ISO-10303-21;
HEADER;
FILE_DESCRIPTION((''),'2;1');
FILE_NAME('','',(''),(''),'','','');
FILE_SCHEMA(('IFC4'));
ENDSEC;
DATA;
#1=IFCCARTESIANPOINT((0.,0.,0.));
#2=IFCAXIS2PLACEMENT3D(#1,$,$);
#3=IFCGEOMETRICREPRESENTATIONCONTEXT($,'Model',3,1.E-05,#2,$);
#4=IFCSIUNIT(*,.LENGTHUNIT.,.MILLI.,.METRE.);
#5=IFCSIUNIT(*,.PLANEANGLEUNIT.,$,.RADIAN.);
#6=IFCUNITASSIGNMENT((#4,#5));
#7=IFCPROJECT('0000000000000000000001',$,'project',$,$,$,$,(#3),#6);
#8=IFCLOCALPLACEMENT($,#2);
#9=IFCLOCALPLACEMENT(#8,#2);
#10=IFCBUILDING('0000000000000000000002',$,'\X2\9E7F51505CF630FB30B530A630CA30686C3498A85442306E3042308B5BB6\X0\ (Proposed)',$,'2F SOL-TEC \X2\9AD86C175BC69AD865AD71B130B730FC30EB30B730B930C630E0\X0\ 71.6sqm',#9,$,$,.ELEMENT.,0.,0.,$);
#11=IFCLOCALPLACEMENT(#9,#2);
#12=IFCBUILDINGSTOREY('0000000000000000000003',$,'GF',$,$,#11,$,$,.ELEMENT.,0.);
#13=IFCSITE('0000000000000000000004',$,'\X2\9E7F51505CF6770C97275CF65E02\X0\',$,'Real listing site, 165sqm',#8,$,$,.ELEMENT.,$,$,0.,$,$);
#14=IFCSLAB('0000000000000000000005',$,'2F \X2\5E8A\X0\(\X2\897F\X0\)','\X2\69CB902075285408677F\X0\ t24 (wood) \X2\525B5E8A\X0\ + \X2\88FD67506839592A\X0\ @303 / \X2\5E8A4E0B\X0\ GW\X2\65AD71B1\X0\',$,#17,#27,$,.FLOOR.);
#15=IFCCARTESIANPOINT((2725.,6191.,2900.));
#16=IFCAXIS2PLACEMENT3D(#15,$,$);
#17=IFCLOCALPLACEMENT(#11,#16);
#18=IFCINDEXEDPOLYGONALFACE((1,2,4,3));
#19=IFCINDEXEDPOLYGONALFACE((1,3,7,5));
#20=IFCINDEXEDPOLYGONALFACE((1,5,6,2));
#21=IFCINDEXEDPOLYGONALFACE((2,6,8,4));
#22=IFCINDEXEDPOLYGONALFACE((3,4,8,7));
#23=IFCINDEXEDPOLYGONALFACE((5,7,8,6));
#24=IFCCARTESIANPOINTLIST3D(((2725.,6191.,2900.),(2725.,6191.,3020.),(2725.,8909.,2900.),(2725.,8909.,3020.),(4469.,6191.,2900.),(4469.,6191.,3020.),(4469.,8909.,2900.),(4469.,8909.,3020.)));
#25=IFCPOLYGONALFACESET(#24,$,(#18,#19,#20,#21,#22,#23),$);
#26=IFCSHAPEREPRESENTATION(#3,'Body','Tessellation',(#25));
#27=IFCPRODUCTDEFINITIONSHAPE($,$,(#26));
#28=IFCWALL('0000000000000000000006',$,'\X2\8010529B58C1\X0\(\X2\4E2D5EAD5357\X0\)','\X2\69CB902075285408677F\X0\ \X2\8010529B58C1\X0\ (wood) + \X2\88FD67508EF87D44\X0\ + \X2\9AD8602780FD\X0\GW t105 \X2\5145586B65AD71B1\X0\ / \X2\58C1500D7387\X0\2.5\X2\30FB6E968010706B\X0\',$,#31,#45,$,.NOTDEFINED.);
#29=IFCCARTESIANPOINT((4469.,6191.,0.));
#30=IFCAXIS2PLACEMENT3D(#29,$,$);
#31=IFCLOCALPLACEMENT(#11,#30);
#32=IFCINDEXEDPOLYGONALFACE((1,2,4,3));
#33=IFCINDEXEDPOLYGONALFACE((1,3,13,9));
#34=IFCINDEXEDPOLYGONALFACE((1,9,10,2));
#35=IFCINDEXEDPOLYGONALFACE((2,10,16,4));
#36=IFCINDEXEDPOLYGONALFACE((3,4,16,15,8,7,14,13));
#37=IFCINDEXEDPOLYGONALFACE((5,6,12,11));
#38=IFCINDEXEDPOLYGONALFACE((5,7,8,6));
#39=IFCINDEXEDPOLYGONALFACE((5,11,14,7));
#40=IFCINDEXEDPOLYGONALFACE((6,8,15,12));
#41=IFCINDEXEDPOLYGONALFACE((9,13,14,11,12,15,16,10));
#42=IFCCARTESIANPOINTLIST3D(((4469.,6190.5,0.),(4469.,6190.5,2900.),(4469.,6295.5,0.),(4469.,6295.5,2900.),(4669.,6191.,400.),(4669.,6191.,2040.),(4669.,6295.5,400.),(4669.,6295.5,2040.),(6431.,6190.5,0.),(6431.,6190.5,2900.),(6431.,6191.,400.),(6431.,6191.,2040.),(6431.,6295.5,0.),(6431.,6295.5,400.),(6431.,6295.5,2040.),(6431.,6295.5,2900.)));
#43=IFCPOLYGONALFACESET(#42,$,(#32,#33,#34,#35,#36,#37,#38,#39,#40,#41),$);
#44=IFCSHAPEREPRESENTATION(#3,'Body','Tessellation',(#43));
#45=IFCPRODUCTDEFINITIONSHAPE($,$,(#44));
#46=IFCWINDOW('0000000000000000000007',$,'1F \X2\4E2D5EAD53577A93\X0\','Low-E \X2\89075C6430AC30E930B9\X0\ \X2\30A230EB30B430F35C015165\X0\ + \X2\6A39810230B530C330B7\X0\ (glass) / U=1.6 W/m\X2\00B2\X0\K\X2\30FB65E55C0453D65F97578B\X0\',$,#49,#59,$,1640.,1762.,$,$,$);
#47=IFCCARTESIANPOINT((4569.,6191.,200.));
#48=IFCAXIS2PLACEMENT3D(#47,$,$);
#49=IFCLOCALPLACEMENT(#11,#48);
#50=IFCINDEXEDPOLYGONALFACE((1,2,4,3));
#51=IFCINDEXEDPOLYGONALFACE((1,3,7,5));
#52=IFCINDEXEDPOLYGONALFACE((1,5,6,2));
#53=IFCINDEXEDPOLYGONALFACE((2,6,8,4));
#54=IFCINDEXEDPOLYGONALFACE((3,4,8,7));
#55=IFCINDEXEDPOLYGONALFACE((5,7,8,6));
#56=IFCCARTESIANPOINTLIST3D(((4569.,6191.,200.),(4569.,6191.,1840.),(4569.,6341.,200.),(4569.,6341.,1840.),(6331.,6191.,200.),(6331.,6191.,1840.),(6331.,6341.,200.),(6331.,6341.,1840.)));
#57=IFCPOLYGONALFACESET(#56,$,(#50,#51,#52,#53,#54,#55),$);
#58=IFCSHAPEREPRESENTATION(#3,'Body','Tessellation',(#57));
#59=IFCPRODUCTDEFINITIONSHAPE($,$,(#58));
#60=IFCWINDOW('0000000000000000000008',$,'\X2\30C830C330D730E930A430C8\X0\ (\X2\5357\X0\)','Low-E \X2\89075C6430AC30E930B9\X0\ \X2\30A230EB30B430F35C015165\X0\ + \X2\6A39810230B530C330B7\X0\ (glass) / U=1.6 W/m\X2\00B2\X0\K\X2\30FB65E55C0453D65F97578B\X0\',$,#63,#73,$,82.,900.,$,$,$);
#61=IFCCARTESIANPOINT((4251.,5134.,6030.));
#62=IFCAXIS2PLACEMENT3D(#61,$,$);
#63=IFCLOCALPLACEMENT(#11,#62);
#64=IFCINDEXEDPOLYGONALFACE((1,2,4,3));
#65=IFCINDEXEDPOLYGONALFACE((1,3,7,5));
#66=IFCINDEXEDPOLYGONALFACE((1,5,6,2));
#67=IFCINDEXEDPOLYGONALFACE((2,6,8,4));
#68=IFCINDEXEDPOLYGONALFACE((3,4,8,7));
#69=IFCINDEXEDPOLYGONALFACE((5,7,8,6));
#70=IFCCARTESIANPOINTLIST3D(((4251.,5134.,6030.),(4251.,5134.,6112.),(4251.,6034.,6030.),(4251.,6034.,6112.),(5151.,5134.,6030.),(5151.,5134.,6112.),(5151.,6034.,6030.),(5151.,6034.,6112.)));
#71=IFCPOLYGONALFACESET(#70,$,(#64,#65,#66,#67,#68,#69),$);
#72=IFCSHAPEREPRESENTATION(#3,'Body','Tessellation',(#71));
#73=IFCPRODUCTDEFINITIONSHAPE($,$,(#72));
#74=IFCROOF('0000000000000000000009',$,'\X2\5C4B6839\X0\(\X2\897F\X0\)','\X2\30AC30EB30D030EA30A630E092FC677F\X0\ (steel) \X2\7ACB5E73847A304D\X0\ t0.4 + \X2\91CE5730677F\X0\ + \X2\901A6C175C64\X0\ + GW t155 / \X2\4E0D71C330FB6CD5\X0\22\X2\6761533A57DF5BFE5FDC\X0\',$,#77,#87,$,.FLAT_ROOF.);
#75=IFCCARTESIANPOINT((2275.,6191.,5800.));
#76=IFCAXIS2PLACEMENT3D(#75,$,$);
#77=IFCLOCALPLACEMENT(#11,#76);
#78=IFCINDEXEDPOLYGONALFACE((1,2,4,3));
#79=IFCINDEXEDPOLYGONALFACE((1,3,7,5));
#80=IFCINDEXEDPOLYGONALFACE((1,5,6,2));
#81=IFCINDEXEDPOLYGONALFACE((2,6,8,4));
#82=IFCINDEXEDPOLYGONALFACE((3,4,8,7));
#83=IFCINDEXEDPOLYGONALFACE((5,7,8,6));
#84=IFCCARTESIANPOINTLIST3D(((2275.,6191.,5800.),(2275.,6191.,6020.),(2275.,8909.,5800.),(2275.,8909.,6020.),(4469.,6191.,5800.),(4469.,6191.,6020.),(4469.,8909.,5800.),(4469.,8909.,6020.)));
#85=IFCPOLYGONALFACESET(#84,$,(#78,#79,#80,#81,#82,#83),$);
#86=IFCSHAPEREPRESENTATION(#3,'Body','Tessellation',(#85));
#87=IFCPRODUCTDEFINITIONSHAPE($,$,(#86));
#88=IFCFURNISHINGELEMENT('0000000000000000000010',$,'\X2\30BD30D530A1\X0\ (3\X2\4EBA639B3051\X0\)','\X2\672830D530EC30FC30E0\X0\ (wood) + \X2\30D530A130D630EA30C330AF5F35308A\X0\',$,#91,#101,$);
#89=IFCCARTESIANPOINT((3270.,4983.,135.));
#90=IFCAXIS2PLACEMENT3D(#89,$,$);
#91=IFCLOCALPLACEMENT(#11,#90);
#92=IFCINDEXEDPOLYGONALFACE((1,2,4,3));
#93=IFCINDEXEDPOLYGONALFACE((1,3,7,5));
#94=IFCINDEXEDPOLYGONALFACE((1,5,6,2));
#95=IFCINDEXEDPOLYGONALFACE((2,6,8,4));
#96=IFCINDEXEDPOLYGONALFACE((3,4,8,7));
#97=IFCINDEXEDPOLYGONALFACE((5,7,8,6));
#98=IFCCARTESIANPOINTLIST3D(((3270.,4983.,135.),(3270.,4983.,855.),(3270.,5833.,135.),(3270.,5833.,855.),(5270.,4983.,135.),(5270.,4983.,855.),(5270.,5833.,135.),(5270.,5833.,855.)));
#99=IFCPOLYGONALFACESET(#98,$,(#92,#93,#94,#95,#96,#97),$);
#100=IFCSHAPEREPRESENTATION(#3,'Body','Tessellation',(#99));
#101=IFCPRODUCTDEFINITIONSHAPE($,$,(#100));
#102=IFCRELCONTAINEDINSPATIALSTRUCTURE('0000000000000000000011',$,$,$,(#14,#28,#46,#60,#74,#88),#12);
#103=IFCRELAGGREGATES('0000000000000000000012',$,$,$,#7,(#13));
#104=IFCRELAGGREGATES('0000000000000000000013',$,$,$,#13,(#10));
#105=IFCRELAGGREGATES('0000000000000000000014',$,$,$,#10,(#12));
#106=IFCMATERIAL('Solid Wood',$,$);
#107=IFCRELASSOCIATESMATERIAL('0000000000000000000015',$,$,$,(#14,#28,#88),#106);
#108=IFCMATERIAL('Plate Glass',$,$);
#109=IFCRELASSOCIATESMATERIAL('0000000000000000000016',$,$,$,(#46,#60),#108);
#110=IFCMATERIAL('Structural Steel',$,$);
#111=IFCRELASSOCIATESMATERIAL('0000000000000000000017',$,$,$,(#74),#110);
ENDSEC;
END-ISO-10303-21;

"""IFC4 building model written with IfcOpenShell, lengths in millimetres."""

from ifc_helpers import new_model, si_unit, frame, frame_2d, origin, place, context, project, spatial, rectangle, extrude, material, element, fill, save


model = new_model("IFC4")

# Units and contexts
model_context = context("Model", 3, precision=1e-05, world=origin())
ifc_project = project(units=[si_unit("LENGTHUNIT", "METRE", prefix="MILLI"), si_unit("PLANEANGLEUNIT", "RADIAN")], contexts=[model_context])

# Site, building, storey
site_placement = place(None, origin())
site = spatial("IfcSite", under=ifc_project, at=site_placement, Name="鹿児島県霧島市", ObjectType="Real listing site, 165sqm", CompositionType="ELEMENT", RefElevation=0.0)
building_placement = place(site_placement, origin())
building = spatial("IfcBuilding", under=site, at=building_placement, Name="鹿児島・サウナと水風呂のある家 (Proposed)", ObjectType="2F SOL-TEC 高気密高断熱シールシステム 71.6sqm", CompositionType="ELEMENT", ElevationOfRefHeight=0.0, ElevationOfTerrain=0.0)
storey_placement = place(building_placement, origin())
storey = spatial("IfcBuildingStorey", under=building, at=storey_placement, Name="GF", CompositionType="ELEMENT", Elevation=0.0)

# Shared definitions
ifc_material_1 = material(Name="Solid Wood")

# Slab
slab_1_placement = place(storey_placement, frame((2725.0, 6191.0, 2900.0)))
element("IfcSlab", 1, at=slab_1_placement, inside=storey, material=ifc_material_1, Name="2F 床(西)", Description="構造用合板 t24 (wood) 剛床 + 製材根太 @303 / 床下 GW断熱", PredefinedType="FLOOR", context=model_context, shape_type="SweptSolid", body=[
    extrude(rectangle(XDim=1744.0, YDim=2718.0, at=frame_2d((872.0, 1359.0))), frame((2725.0, 6191.0, 2900.0)), (0.0, 0.0, 1.0), 120.0),
])

# Wall, opening, window
wall_placement = place(storey_placement, frame((4469.0, 6191.0, 0.0)))
wall = element("IfcWall", 2, at=wall_placement, inside=storey, material=ifc_material_1, Name="耐力壁(中庭南)", Description="構造用合板 耐力壁 (wood) + 製材軸組 + 高性能GW t105 充填断熱 / 壁倍率2.5・準耐火", PredefinedType="NOTDEFINED", context=model_context, shape_type="SweptSolid", body=[
    extrude(rectangle(XDim=1962.0, YDim=105.0, at=frame_2d((981.0, 52.0))), frame((4469.0, 6191.0, 0.0)), (0.0, 0.0, 1.0), 2900.0),
])
opening_placement = place(storey_placement, frame((4569.0, 6191.0, 200.0)))
opening = element("IfcOpeningElement", 3, at=opening_placement, cuts=wall, PredefinedType="NOTDEFINED", context=model_context, shape_type="SweptSolid", body=[
    extrude(rectangle(XDim=1762.0, YDim=150.0, at=frame_2d((881.0, 75.0))), frame((4569.0, 6191.0, 200.0)), (0.0, 0.0, 1.0), 1640.0),
])
ifc_material_2 = material(Name="Plate Glass")
window_1_placement = place(storey_placement, frame((4569.0, 6191.0, 200.0)))
window_1 = element("IfcWindow", 4, at=window_1_placement, inside=storey, material=ifc_material_2, Name="1F 中庭南窓", Description="Low-E 複層ガラス アルゴン封入 + 樹脂サッシ (glass) / U=1.6 W/m²K・日射取得型", OverallHeight=1640.0, OverallWidth=1762.0, context=model_context, shape_type="SweptSolid", body=[
    extrude(rectangle(XDim=1762.0, YDim=150.0, at=frame_2d((881.0, 75.0))), frame((4569.0, 6191.0, 200.0)), (0.0, 0.0, 1.0), 1640.0),
])
fill(opening, window_1)

# Window
window_2_placement = place(storey_placement, frame((4251.0, 5134.0, 6030.0)))
element("IfcWindow", 5, at=window_2_placement, inside=storey, material=ifc_material_2, Name="トップライト (南)", Description="Low-E 複層ガラス アルゴン封入 + 樹脂サッシ (glass) / U=1.6 W/m²K・日射取得型", OverallHeight=82.0, OverallWidth=900.0, context=model_context, shape_type="SweptSolid", body=[
    extrude(rectangle(XDim=900.0, YDim=900.0, at=frame_2d((450.0, 450.0))), frame((4251.0, 5134.0, 6030.0)), (0.0, 0.0, 1.0), 82.0),
])

# Roof
ifc_material_3 = material(Name="Structural Steel")
for number, where, name in (
    (6, (2275.0, 6191.0, 5800.0), "屋根(西)"),
):
    element("IfcRoof", number, at=place(storey_placement, frame(where)), inside=storey, material=ifc_material_3, Name=name, Description="ガルバリウム鋼板 (steel) 立平葺き t0.4 + 野地板 + 通気層 + GW t155 / 不燃・法22条区域対応", PredefinedType="FLAT_ROOF", context=model_context, shape_type="SweptSolid", body=[
        extrude(rectangle(XDim=2194.0, YDim=2718.0, at=frame_2d((1097.0, 1359.0))), frame((2275.0, 6191.0, 5800.0)), (0.0, 0.0, 1.0), 220.0),
    ])

# Furnishing element
furnishing_placement = place(storey_placement, frame((3270.0, 4983.0, 135.0)))
element("IfcFurnishingElement", 7, at=furnishing_placement, inside=storey, material=ifc_material_1, Name="ソファ (3人掛け)", Description="木フレーム (wood) + ファブリック張り", context=model_context, shape_type="SweptSolid", body=[
    extrude(rectangle(XDim=2000.0, YDim=850.0, at=frame_2d((1000.0, 425.0))), frame((3270.0, 4983.0, 135.0)), (0.0, 0.0, 1.0), 720.0),
])

save(model, "model.ifc")
